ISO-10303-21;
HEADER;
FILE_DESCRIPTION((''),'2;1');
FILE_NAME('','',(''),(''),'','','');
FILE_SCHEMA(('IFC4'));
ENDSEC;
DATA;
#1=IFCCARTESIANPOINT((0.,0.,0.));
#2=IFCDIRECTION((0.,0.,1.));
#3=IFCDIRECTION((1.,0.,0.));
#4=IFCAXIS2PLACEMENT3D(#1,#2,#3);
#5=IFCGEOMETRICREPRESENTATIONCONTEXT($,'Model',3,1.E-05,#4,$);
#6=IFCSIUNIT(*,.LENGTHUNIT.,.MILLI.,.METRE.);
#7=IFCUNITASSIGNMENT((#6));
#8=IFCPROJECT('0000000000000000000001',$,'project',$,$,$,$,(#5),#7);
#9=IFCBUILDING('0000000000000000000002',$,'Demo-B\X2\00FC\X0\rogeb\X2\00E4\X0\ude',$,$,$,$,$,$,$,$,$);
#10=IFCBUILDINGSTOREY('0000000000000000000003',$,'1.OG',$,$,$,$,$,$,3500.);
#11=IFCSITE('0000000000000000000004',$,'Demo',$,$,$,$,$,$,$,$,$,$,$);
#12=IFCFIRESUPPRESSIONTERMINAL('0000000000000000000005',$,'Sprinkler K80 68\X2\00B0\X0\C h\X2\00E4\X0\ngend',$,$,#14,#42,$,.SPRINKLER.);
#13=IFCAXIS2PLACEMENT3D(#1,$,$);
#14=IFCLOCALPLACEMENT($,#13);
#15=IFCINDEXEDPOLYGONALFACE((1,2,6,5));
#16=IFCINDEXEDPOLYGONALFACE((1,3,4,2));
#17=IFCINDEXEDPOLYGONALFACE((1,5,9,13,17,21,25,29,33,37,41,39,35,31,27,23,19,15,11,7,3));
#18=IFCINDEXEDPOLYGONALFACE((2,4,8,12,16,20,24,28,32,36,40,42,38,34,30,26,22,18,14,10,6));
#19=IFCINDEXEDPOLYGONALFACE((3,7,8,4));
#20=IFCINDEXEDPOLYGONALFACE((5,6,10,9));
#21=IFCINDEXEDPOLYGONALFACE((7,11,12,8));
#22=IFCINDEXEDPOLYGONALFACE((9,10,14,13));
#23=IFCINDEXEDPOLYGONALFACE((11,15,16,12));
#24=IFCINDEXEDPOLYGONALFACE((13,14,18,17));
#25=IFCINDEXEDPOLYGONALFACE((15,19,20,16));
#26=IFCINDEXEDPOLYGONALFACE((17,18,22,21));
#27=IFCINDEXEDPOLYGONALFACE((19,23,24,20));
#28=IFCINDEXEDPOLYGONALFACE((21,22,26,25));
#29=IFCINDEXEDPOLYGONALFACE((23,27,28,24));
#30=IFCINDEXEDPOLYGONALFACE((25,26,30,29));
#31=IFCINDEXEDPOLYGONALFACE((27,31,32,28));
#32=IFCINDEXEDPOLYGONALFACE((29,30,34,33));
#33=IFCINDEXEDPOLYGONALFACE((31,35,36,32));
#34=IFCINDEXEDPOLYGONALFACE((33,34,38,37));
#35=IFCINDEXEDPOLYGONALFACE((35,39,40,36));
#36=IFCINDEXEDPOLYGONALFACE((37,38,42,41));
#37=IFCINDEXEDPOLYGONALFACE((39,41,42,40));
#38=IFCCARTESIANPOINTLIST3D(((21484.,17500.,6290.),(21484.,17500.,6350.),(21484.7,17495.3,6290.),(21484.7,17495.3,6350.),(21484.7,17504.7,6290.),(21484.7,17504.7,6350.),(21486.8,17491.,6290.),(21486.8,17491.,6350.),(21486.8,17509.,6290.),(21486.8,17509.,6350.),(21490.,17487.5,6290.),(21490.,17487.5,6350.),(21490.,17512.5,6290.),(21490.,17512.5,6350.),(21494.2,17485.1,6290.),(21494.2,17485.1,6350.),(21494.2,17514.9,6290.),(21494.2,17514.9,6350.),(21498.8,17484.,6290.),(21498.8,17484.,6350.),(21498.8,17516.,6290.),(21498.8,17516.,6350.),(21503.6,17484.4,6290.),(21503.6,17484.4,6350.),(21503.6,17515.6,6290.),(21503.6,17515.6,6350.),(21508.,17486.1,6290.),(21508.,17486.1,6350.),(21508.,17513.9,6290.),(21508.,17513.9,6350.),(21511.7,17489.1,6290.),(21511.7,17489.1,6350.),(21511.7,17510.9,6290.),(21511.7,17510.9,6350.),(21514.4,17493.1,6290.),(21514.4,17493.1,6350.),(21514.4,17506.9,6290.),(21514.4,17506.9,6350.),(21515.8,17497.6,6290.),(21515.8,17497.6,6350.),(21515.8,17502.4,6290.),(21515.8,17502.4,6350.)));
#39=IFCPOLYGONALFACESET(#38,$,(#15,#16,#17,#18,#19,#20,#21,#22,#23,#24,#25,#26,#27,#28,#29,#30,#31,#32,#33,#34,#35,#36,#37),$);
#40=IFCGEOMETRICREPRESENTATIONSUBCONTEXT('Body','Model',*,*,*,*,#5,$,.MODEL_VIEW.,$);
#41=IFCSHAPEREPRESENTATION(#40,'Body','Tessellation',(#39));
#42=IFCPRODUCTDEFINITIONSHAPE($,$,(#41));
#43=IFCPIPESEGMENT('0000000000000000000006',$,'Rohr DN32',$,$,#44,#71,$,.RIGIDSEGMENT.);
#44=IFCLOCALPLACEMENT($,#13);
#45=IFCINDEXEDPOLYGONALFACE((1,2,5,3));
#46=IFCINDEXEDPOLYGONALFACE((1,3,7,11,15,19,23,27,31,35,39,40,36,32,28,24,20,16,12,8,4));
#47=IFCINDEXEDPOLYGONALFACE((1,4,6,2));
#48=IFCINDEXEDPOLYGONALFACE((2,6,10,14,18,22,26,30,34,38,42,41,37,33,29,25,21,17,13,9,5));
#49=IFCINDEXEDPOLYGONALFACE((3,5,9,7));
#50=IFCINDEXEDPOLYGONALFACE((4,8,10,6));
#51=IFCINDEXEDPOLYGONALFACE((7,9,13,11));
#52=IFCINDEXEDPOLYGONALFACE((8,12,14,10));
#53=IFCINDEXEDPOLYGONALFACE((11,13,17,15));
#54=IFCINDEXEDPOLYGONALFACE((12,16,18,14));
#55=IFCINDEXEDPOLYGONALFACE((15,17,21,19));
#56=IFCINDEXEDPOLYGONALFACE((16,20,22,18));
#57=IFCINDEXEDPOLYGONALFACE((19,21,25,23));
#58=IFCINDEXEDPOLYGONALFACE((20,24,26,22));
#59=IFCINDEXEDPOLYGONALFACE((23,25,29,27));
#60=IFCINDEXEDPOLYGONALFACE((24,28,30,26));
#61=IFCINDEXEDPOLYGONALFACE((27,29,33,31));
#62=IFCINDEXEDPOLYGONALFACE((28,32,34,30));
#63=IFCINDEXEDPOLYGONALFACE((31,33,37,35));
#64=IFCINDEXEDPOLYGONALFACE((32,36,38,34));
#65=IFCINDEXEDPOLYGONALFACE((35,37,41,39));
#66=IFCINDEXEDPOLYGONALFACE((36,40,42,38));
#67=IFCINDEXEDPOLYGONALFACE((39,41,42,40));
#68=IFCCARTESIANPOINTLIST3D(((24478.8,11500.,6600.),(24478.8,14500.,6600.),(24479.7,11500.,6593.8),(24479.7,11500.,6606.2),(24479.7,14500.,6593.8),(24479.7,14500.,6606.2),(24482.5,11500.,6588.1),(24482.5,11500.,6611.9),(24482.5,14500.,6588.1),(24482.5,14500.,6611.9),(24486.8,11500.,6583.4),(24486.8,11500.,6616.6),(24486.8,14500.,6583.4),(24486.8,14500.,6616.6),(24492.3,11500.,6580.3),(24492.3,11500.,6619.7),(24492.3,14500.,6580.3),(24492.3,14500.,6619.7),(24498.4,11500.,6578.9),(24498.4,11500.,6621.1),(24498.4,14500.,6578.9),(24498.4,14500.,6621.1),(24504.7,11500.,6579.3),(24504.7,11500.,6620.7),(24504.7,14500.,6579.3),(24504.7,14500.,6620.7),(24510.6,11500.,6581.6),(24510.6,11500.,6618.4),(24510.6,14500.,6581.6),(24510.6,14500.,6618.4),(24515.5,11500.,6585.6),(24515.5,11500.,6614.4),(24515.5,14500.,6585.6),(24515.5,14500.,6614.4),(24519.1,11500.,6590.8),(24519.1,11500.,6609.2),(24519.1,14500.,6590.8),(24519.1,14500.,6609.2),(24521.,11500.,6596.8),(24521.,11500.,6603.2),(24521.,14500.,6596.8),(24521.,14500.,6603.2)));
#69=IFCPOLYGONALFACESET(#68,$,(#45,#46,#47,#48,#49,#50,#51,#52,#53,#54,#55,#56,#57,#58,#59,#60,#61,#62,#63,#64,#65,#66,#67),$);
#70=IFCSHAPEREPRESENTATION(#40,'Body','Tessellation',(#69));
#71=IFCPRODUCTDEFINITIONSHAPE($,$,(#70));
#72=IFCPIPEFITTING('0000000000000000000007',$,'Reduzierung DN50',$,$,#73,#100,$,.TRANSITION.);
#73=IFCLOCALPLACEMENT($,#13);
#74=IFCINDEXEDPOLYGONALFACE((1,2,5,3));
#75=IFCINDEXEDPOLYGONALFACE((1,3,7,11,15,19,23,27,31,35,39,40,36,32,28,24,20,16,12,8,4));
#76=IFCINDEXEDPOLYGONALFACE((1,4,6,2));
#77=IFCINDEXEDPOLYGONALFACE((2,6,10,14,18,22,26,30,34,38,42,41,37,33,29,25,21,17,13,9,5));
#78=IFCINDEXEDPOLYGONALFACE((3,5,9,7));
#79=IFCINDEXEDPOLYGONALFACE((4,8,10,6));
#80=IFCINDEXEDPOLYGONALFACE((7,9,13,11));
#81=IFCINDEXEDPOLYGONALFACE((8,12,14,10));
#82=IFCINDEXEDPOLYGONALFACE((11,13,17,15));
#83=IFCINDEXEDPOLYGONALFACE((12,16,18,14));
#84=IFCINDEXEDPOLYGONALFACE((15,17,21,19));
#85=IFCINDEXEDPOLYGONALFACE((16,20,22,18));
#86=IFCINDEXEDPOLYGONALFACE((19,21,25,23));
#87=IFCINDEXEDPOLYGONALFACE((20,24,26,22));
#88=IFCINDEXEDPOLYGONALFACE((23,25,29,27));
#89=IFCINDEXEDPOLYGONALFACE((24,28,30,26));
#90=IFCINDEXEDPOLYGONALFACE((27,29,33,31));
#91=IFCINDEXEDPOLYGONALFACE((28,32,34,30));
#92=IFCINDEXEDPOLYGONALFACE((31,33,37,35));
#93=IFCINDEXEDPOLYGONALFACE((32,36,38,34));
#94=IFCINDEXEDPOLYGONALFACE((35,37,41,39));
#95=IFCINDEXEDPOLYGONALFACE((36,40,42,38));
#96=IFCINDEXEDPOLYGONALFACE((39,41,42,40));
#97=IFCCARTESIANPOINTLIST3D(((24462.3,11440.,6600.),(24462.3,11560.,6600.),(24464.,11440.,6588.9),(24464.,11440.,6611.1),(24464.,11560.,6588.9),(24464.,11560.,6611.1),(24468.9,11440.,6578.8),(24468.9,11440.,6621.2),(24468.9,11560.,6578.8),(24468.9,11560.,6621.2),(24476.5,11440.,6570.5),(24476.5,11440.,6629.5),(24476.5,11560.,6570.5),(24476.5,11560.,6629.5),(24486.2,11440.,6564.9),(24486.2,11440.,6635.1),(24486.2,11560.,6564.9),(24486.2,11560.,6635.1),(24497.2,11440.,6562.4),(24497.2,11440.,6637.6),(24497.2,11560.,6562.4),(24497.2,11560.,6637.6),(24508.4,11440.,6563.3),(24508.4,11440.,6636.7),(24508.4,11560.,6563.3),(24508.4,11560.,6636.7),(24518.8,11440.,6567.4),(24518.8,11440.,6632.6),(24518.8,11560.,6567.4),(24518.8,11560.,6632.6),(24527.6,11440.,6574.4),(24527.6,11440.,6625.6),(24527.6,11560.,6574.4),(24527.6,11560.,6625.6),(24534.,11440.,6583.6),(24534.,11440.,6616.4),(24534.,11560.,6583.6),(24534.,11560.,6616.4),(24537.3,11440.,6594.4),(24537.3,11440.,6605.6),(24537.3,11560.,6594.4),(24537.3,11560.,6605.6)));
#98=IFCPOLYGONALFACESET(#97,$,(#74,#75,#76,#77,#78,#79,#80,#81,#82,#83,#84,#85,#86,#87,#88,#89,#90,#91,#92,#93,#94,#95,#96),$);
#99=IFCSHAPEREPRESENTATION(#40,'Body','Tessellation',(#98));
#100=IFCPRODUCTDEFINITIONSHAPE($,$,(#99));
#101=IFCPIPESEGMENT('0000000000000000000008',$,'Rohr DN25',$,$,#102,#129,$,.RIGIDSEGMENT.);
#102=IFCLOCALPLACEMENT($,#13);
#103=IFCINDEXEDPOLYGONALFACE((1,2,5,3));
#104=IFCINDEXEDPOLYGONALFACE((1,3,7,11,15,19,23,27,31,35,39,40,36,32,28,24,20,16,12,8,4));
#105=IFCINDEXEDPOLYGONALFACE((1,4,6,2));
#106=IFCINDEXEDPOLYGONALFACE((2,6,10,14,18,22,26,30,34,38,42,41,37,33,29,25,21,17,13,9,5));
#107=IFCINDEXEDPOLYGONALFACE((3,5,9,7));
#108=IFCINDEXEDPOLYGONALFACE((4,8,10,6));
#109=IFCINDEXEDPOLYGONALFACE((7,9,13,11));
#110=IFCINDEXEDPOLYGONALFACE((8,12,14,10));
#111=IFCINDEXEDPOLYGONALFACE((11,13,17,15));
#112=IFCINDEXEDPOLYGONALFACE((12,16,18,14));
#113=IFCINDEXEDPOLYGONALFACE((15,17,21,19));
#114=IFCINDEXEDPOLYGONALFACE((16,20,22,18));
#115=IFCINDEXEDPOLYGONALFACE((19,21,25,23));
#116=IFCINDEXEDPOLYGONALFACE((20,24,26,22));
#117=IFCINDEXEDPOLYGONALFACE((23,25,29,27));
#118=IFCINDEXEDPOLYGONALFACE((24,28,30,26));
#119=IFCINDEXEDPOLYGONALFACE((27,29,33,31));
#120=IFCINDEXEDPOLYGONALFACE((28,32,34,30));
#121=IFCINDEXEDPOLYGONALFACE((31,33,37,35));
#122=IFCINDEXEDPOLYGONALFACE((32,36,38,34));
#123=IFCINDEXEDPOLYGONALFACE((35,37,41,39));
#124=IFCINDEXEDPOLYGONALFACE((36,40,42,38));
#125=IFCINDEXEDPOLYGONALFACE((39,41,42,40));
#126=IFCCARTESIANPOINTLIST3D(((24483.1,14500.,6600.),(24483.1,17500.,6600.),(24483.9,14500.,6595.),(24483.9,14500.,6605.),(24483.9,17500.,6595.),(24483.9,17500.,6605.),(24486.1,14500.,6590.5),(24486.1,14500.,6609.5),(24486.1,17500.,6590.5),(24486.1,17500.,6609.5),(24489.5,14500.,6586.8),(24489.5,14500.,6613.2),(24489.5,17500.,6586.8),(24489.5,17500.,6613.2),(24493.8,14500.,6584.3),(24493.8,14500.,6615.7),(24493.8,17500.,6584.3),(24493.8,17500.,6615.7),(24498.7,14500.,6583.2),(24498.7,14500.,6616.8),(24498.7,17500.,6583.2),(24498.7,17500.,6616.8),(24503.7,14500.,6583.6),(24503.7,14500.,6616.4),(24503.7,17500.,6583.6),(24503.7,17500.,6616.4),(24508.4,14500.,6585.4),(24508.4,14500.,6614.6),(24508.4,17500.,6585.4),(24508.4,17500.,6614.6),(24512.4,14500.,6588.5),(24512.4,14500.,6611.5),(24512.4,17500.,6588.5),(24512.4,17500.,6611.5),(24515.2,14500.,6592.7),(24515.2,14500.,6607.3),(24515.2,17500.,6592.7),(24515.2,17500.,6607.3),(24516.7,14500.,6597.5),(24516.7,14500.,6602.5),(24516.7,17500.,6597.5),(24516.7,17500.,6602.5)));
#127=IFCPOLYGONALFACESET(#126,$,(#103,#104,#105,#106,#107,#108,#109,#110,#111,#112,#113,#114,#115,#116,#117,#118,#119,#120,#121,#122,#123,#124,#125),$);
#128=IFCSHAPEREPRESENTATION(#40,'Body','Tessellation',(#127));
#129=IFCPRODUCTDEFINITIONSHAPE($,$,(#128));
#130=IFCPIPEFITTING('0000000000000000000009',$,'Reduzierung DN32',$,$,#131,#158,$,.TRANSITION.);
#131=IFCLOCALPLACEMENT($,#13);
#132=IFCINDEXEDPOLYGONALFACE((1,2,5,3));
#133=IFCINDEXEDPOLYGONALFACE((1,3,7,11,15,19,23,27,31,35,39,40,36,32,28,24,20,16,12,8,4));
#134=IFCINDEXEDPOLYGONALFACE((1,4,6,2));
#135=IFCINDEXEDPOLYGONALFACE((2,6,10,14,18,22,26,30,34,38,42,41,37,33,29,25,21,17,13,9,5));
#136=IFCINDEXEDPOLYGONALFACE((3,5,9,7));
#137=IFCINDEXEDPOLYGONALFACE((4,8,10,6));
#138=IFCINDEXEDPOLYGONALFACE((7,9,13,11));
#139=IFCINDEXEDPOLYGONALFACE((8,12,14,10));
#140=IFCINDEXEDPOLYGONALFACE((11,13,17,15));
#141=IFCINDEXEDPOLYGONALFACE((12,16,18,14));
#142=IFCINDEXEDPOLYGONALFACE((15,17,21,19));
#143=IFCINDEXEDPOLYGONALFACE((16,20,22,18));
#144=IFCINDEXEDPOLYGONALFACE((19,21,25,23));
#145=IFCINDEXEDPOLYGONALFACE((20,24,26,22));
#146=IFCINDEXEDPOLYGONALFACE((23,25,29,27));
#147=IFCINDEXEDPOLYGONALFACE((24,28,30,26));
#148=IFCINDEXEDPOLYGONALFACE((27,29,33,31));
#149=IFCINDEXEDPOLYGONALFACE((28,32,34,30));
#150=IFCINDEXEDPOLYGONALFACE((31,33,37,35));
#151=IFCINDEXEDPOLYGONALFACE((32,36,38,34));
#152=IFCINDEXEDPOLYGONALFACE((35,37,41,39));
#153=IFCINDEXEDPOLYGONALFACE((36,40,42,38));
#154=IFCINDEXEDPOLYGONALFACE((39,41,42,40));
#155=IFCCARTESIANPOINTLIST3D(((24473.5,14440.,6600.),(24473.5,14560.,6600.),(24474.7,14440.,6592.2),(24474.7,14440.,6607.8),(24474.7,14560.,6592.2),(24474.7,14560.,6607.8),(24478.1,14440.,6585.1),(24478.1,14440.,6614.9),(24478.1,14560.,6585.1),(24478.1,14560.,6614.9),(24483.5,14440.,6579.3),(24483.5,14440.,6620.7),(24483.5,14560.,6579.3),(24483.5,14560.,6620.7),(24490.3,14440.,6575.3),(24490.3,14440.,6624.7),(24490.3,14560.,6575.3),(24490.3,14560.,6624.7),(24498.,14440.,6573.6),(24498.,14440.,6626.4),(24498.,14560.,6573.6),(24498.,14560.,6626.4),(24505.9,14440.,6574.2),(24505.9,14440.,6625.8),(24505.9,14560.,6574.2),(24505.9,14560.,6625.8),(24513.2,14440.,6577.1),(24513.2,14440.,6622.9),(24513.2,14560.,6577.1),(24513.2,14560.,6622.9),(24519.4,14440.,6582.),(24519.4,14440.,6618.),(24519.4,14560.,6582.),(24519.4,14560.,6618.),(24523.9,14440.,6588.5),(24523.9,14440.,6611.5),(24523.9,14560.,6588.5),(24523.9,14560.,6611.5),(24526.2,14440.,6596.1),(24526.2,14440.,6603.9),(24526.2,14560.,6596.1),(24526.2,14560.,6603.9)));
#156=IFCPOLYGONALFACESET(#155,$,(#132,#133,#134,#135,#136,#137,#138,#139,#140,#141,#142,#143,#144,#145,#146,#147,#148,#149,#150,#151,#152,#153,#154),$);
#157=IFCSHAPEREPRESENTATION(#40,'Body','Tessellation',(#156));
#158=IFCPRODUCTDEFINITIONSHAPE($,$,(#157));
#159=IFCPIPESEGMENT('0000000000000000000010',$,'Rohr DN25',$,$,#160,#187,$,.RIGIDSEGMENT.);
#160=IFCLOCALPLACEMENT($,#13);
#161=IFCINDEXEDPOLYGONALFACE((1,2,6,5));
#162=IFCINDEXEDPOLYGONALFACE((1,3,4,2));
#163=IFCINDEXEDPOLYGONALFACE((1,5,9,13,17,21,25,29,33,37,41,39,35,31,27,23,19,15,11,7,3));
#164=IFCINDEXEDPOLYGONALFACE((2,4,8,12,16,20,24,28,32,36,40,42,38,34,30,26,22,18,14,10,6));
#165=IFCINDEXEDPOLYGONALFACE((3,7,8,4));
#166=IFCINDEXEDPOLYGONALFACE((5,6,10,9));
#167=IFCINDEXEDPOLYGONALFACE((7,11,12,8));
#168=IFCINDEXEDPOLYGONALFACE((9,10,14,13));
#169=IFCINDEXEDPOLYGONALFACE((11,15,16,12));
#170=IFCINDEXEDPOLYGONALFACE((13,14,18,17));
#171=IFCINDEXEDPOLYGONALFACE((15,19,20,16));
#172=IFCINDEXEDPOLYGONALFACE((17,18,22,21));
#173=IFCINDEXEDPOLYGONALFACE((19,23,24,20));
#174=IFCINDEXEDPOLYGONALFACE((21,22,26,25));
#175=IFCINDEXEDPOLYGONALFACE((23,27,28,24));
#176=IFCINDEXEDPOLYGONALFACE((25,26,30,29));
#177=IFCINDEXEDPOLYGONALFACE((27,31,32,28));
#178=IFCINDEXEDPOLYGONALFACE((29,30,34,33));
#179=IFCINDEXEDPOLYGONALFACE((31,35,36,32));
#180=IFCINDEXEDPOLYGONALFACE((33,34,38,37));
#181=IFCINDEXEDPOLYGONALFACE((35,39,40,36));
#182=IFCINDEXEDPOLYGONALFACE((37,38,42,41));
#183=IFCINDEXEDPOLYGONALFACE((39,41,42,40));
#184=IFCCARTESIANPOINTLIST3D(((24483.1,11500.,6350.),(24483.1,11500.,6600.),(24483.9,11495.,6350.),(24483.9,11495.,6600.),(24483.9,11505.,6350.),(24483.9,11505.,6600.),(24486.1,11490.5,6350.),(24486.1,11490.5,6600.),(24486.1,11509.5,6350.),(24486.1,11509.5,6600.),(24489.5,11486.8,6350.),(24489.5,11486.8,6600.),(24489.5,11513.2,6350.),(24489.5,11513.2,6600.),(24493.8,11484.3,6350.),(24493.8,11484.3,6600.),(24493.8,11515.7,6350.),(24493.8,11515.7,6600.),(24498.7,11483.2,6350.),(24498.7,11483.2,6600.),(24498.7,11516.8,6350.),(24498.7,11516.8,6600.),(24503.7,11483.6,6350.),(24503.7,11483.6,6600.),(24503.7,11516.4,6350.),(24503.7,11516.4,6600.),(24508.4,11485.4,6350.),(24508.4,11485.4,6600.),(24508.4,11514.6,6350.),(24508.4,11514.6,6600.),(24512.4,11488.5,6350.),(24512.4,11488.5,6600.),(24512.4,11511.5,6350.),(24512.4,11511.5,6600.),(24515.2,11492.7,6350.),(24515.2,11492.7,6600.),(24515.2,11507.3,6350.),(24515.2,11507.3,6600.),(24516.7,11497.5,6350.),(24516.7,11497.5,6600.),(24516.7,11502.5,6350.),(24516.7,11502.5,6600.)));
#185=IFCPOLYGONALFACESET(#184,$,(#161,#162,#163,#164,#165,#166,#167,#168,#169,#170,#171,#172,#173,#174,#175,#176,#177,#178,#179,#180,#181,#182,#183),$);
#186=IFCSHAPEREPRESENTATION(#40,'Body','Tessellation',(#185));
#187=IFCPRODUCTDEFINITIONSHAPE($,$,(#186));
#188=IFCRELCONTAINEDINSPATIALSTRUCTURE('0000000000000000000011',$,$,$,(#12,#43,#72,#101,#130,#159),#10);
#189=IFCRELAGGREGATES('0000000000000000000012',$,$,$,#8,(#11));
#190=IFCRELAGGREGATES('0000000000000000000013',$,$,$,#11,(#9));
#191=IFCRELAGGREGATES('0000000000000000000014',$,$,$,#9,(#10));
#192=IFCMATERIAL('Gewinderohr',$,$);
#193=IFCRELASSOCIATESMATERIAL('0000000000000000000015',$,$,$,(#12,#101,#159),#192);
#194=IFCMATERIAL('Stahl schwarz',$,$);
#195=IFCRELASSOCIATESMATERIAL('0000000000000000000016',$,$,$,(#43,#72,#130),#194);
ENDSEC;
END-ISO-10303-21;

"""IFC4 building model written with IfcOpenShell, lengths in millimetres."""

from ifc_helpers import new_model, si_unit, frame, origin_with_axes, place, context, subcontext, project, spatial, circle, extrude, material, element, save


model = new_model("IFC4")

# Units and contexts
model_context = context("Model", 3, precision=1e-05, world=origin_with_axes())
body_context = subcontext(model_context, "Body", "Model", "MODEL_VIEW")
ifc_project = project(units=[si_unit("LENGTHUNIT", "METRE", prefix="MILLI")], contexts=[model_context])

# Site, building, storey
site = spatial("IfcSite", under=ifc_project, Name="Demo")
building = spatial("IfcBuilding", under=site, Name="Demo-Bürogebäude")
storey = spatial("IfcBuildingStorey", under=building, Name="1.OG", Elevation=3500.0)

# Shared definitions
ifc_material_1 = material(Name="Stahl schwarz")

# Shared definitions
ifc_material_2 = material(Name="Gewinderohr")

# Fire suppression terminal
fire_suppression_terminal_1_placement = place(None, frame((21500.0, 17500.0, 6350.0), z_axis=(0.0, 0.0, -1.0), x_axis=(-1.0, 0.0, 0.0)))
element("IfcFireSuppressionTerminal", 1, at=fire_suppression_terminal_1_placement, inside=storey, material=ifc_material_2, Name="Sprinkler K80 68°C hängend", PredefinedType="SPRINKLER", context=body_context, shape_type="SweptSolid", body=[
    extrude(circle(Radius=16.0), origin_with_axes(), (0.0, 0.0, 1.0), 60.0),
])

# Pipe segment
pipe_segment_1_placement = place(None, frame((24500.0, 11500.0, 6600.0), z_axis=(0.0, 1.0, 0.0), x_axis=(-1.0, 0.0, 0.0)))
element("IfcPipeSegment", 2, at=pipe_segment_1_placement, inside=storey, material=ifc_material_1, Name="Rohr DN32", PredefinedType="RIGIDSEGMENT", context=body_context, shape_type="SweptSolid", body=[
    extrude(circle(Radius=21.2), origin_with_axes(), (0.0, 0.0, 1.0), 3000.0),
])

# Pipe fitting
pipe_fitting_1_placement = place(None, frame((24500.0, 11440.0, 6600.0), z_axis=(0.0, 1.0, 0.0), x_axis=(-1.0, 0.0, 0.0)))
element("IfcPipeFitting", 3, at=pipe_fitting_1_placement, inside=storey, material=ifc_material_1, Name="Reduzierung DN50", PredefinedType="TRANSITION", context=body_context, shape_type="SweptSolid", body=[
    extrude(circle(Radius=37.7), origin_with_axes(), (0.0, 0.0, 1.0), 120.0),
])

# Pipe segment
pipe_segment_2_placement = place(None, frame((24500.0, 14500.0, 6600.0), z_axis=(0.0, 1.0, 0.0), x_axis=(-1.0, 0.0, 0.0)))
element("IfcPipeSegment", 4, at=pipe_segment_2_placement, inside=storey, material=ifc_material_2, Name="Rohr DN25", PredefinedType="RIGIDSEGMENT", context=body_context, shape_type="SweptSolid", body=[
    extrude(circle(Radius=16.9), origin_with_axes(), (0.0, 0.0, 1.0), 3000.0),
])

# Pipe fitting
pipe_fitting_2_placement = place(None, frame((24500.0, 14440.0, 6600.0), z_axis=(0.0, 1.0, 0.0), x_axis=(-1.0, 0.0, 0.0)))
element("IfcPipeFitting", 5, at=pipe_fitting_2_placement, inside=storey, material=ifc_material_1, Name="Reduzierung DN32", PredefinedType="TRANSITION", context=body_context, shape_type="SweptSolid", body=[
    extrude(circle(Radius=26.5), origin_with_axes(), (0.0, 0.0, 1.0), 120.0),
])

# Pipe segment
pipe_segment_3_placement = place(None, frame((24500.0, 11500.0, 6600.0), z_axis=(0.0, 0.0, -1.0), x_axis=(-1.0, 0.0, 0.0)))
element("IfcPipeSegment", 6, at=pipe_segment_3_placement, inside=storey, material=ifc_material_2, Name="Rohr DN25", PredefinedType="RIGIDSEGMENT", context=body_context, shape_type="SweptSolid", body=[
    extrude(circle(Radius=16.9), origin_with_axes(), (0.0, 0.0, 1.0), 250.0),
])

save(model, "model.ifc")
